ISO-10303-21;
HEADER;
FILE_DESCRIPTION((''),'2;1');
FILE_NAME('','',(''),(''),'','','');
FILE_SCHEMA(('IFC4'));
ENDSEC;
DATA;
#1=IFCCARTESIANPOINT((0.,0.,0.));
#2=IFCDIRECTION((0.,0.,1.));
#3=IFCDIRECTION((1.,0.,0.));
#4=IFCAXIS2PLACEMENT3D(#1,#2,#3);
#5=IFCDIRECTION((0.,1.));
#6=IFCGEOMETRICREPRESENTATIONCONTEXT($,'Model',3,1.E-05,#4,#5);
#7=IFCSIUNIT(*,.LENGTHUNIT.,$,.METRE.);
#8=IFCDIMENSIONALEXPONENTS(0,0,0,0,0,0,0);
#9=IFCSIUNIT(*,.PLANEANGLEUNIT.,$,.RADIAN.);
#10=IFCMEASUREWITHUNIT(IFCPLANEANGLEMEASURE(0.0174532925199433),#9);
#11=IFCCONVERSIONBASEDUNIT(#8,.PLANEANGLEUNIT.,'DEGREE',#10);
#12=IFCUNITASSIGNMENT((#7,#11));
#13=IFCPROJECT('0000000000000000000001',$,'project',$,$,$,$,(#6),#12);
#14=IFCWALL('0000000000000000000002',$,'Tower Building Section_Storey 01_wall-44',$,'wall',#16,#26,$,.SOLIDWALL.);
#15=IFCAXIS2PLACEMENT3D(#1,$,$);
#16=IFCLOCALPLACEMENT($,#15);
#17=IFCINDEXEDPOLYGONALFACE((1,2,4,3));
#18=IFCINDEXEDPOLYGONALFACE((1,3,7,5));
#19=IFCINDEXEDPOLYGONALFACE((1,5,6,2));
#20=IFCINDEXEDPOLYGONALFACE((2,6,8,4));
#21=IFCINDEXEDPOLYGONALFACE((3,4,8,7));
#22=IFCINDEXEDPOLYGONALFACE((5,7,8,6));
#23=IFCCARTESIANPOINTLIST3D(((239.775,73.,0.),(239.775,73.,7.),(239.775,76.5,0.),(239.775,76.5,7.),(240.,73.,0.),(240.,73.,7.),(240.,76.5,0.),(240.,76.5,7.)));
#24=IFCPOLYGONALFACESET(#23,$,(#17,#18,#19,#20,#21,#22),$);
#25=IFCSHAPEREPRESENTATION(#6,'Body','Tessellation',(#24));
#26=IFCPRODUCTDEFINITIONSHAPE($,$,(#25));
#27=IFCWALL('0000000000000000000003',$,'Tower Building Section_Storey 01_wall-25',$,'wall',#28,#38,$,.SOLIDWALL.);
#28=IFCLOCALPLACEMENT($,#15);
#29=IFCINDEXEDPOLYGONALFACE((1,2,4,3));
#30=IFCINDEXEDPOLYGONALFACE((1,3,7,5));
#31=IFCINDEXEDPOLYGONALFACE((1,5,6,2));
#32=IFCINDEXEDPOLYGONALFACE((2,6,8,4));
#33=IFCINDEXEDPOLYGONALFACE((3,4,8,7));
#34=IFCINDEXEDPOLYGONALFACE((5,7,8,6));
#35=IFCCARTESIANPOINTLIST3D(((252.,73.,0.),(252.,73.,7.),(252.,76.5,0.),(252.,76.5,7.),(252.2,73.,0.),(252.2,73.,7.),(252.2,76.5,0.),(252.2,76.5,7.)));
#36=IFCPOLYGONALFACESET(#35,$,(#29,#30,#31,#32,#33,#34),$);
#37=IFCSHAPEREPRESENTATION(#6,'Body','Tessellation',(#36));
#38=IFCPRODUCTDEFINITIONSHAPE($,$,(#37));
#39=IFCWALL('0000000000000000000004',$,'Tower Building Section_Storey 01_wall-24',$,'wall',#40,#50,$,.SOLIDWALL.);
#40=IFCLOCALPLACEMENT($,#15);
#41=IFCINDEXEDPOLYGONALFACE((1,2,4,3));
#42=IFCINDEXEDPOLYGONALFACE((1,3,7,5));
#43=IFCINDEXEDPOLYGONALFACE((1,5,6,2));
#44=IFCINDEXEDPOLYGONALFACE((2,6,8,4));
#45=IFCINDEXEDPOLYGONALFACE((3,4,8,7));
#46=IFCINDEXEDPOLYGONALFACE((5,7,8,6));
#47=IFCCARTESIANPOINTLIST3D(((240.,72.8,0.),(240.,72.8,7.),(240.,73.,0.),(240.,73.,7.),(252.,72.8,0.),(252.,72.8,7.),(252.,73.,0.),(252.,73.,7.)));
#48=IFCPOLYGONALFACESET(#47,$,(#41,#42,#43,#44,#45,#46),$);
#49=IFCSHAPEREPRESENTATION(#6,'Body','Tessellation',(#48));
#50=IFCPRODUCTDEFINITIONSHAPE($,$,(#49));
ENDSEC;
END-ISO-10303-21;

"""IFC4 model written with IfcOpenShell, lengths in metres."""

from ifc_helpers import new_model, entity, si_unit, converted_unit, direction, frame, origin_with_axes, place, context, project, polyline, outline, extrude, element, save


model = new_model("IFC4")

# Units and contexts
model_context = context("Model", 3, precision=1e-05, world=origin_with_axes(), true_north=direction((0.0, 1.0)))
ifc_project = project(units=[si_unit("LENGTHUNIT", "METRE"), converted_unit("PLANEANGLEUNIT", "DEGREE", entity("IfcPlaneAngleMeasure", 0.0174532925199433), si_unit("PLANEANGLEUNIT", "RADIAN"), dimensions=[0, 0, 0, 0, 0, 0, 0])], contexts=[model_context])

# Shared definitions
placement_1 = place(None, origin_with_axes())
placement_2 = place(placement_1, origin_with_axes())

# Walls
wall_1_placement = place(placement_2, frame((240.0, 74.75, 3.5), z_axis=(-1.0, 0.0, 0.0), x_axis=(0.0, 0.0, 1.0)))
element("IfcWall", 1, at=wall_1_placement, Name="Tower Building Section_Storey 01_wall-44", ObjectType="wall", PredefinedType="SOLIDWALL", context=model_context, body=[
    extrude(outline(polyline([(-3.5, -1.75, 0.0), (3.5, -1.75, 0.0), (3.5, 1.75, 0.0), (-3.5, 1.75, 0.0), (-3.5, -1.75, 0.0)])), origin_with_axes(), (0.0, 0.0, 1.0), 0.225),
])
wall_2_placement = place(placement_2, frame((252.2, 74.75, 3.5), z_axis=(-1.0, 0.0, 0.0), x_axis=(0.0, 0.0, 1.0)))
element("IfcWall", 2, at=wall_2_placement, Name="Tower Building Section_Storey 01_wall-25", ObjectType="wall", PredefinedType="SOLIDWALL", context=model_context, body=[
    extrude(outline(polyline([(-3.5, -1.75, 0.0), (3.5, -1.75, 0.0), (3.5, 1.75, 0.0), (-3.5, 1.75, 0.0), (-3.5, -1.75, 0.0)])), origin_with_axes(), (0.0, 0.0, 1.0), 0.2),
])
wall_3_placement = place(placement_2, frame((246.0, 72.8, 3.5), z_axis=(0.0, 1.0, 0.0), x_axis=(0.0, 0.0, 1.0)))
element("IfcWall", 3, at=wall_3_placement, Name="Tower Building Section_Storey 01_wall-24", ObjectType="wall", PredefinedType="SOLIDWALL", context=model_context, body=[
    extrude(outline(polyline([(-3.5, -6.0, 0.0), (3.5, -6.0, 0.0), (3.5, 6.0, 0.0), (-3.5, 6.0, 0.0), (-3.5, -6.0, 0.0)])), origin_with_axes(), (0.0, 0.0, 1.0), 0.2),
])

save(model, "model.ifc")
